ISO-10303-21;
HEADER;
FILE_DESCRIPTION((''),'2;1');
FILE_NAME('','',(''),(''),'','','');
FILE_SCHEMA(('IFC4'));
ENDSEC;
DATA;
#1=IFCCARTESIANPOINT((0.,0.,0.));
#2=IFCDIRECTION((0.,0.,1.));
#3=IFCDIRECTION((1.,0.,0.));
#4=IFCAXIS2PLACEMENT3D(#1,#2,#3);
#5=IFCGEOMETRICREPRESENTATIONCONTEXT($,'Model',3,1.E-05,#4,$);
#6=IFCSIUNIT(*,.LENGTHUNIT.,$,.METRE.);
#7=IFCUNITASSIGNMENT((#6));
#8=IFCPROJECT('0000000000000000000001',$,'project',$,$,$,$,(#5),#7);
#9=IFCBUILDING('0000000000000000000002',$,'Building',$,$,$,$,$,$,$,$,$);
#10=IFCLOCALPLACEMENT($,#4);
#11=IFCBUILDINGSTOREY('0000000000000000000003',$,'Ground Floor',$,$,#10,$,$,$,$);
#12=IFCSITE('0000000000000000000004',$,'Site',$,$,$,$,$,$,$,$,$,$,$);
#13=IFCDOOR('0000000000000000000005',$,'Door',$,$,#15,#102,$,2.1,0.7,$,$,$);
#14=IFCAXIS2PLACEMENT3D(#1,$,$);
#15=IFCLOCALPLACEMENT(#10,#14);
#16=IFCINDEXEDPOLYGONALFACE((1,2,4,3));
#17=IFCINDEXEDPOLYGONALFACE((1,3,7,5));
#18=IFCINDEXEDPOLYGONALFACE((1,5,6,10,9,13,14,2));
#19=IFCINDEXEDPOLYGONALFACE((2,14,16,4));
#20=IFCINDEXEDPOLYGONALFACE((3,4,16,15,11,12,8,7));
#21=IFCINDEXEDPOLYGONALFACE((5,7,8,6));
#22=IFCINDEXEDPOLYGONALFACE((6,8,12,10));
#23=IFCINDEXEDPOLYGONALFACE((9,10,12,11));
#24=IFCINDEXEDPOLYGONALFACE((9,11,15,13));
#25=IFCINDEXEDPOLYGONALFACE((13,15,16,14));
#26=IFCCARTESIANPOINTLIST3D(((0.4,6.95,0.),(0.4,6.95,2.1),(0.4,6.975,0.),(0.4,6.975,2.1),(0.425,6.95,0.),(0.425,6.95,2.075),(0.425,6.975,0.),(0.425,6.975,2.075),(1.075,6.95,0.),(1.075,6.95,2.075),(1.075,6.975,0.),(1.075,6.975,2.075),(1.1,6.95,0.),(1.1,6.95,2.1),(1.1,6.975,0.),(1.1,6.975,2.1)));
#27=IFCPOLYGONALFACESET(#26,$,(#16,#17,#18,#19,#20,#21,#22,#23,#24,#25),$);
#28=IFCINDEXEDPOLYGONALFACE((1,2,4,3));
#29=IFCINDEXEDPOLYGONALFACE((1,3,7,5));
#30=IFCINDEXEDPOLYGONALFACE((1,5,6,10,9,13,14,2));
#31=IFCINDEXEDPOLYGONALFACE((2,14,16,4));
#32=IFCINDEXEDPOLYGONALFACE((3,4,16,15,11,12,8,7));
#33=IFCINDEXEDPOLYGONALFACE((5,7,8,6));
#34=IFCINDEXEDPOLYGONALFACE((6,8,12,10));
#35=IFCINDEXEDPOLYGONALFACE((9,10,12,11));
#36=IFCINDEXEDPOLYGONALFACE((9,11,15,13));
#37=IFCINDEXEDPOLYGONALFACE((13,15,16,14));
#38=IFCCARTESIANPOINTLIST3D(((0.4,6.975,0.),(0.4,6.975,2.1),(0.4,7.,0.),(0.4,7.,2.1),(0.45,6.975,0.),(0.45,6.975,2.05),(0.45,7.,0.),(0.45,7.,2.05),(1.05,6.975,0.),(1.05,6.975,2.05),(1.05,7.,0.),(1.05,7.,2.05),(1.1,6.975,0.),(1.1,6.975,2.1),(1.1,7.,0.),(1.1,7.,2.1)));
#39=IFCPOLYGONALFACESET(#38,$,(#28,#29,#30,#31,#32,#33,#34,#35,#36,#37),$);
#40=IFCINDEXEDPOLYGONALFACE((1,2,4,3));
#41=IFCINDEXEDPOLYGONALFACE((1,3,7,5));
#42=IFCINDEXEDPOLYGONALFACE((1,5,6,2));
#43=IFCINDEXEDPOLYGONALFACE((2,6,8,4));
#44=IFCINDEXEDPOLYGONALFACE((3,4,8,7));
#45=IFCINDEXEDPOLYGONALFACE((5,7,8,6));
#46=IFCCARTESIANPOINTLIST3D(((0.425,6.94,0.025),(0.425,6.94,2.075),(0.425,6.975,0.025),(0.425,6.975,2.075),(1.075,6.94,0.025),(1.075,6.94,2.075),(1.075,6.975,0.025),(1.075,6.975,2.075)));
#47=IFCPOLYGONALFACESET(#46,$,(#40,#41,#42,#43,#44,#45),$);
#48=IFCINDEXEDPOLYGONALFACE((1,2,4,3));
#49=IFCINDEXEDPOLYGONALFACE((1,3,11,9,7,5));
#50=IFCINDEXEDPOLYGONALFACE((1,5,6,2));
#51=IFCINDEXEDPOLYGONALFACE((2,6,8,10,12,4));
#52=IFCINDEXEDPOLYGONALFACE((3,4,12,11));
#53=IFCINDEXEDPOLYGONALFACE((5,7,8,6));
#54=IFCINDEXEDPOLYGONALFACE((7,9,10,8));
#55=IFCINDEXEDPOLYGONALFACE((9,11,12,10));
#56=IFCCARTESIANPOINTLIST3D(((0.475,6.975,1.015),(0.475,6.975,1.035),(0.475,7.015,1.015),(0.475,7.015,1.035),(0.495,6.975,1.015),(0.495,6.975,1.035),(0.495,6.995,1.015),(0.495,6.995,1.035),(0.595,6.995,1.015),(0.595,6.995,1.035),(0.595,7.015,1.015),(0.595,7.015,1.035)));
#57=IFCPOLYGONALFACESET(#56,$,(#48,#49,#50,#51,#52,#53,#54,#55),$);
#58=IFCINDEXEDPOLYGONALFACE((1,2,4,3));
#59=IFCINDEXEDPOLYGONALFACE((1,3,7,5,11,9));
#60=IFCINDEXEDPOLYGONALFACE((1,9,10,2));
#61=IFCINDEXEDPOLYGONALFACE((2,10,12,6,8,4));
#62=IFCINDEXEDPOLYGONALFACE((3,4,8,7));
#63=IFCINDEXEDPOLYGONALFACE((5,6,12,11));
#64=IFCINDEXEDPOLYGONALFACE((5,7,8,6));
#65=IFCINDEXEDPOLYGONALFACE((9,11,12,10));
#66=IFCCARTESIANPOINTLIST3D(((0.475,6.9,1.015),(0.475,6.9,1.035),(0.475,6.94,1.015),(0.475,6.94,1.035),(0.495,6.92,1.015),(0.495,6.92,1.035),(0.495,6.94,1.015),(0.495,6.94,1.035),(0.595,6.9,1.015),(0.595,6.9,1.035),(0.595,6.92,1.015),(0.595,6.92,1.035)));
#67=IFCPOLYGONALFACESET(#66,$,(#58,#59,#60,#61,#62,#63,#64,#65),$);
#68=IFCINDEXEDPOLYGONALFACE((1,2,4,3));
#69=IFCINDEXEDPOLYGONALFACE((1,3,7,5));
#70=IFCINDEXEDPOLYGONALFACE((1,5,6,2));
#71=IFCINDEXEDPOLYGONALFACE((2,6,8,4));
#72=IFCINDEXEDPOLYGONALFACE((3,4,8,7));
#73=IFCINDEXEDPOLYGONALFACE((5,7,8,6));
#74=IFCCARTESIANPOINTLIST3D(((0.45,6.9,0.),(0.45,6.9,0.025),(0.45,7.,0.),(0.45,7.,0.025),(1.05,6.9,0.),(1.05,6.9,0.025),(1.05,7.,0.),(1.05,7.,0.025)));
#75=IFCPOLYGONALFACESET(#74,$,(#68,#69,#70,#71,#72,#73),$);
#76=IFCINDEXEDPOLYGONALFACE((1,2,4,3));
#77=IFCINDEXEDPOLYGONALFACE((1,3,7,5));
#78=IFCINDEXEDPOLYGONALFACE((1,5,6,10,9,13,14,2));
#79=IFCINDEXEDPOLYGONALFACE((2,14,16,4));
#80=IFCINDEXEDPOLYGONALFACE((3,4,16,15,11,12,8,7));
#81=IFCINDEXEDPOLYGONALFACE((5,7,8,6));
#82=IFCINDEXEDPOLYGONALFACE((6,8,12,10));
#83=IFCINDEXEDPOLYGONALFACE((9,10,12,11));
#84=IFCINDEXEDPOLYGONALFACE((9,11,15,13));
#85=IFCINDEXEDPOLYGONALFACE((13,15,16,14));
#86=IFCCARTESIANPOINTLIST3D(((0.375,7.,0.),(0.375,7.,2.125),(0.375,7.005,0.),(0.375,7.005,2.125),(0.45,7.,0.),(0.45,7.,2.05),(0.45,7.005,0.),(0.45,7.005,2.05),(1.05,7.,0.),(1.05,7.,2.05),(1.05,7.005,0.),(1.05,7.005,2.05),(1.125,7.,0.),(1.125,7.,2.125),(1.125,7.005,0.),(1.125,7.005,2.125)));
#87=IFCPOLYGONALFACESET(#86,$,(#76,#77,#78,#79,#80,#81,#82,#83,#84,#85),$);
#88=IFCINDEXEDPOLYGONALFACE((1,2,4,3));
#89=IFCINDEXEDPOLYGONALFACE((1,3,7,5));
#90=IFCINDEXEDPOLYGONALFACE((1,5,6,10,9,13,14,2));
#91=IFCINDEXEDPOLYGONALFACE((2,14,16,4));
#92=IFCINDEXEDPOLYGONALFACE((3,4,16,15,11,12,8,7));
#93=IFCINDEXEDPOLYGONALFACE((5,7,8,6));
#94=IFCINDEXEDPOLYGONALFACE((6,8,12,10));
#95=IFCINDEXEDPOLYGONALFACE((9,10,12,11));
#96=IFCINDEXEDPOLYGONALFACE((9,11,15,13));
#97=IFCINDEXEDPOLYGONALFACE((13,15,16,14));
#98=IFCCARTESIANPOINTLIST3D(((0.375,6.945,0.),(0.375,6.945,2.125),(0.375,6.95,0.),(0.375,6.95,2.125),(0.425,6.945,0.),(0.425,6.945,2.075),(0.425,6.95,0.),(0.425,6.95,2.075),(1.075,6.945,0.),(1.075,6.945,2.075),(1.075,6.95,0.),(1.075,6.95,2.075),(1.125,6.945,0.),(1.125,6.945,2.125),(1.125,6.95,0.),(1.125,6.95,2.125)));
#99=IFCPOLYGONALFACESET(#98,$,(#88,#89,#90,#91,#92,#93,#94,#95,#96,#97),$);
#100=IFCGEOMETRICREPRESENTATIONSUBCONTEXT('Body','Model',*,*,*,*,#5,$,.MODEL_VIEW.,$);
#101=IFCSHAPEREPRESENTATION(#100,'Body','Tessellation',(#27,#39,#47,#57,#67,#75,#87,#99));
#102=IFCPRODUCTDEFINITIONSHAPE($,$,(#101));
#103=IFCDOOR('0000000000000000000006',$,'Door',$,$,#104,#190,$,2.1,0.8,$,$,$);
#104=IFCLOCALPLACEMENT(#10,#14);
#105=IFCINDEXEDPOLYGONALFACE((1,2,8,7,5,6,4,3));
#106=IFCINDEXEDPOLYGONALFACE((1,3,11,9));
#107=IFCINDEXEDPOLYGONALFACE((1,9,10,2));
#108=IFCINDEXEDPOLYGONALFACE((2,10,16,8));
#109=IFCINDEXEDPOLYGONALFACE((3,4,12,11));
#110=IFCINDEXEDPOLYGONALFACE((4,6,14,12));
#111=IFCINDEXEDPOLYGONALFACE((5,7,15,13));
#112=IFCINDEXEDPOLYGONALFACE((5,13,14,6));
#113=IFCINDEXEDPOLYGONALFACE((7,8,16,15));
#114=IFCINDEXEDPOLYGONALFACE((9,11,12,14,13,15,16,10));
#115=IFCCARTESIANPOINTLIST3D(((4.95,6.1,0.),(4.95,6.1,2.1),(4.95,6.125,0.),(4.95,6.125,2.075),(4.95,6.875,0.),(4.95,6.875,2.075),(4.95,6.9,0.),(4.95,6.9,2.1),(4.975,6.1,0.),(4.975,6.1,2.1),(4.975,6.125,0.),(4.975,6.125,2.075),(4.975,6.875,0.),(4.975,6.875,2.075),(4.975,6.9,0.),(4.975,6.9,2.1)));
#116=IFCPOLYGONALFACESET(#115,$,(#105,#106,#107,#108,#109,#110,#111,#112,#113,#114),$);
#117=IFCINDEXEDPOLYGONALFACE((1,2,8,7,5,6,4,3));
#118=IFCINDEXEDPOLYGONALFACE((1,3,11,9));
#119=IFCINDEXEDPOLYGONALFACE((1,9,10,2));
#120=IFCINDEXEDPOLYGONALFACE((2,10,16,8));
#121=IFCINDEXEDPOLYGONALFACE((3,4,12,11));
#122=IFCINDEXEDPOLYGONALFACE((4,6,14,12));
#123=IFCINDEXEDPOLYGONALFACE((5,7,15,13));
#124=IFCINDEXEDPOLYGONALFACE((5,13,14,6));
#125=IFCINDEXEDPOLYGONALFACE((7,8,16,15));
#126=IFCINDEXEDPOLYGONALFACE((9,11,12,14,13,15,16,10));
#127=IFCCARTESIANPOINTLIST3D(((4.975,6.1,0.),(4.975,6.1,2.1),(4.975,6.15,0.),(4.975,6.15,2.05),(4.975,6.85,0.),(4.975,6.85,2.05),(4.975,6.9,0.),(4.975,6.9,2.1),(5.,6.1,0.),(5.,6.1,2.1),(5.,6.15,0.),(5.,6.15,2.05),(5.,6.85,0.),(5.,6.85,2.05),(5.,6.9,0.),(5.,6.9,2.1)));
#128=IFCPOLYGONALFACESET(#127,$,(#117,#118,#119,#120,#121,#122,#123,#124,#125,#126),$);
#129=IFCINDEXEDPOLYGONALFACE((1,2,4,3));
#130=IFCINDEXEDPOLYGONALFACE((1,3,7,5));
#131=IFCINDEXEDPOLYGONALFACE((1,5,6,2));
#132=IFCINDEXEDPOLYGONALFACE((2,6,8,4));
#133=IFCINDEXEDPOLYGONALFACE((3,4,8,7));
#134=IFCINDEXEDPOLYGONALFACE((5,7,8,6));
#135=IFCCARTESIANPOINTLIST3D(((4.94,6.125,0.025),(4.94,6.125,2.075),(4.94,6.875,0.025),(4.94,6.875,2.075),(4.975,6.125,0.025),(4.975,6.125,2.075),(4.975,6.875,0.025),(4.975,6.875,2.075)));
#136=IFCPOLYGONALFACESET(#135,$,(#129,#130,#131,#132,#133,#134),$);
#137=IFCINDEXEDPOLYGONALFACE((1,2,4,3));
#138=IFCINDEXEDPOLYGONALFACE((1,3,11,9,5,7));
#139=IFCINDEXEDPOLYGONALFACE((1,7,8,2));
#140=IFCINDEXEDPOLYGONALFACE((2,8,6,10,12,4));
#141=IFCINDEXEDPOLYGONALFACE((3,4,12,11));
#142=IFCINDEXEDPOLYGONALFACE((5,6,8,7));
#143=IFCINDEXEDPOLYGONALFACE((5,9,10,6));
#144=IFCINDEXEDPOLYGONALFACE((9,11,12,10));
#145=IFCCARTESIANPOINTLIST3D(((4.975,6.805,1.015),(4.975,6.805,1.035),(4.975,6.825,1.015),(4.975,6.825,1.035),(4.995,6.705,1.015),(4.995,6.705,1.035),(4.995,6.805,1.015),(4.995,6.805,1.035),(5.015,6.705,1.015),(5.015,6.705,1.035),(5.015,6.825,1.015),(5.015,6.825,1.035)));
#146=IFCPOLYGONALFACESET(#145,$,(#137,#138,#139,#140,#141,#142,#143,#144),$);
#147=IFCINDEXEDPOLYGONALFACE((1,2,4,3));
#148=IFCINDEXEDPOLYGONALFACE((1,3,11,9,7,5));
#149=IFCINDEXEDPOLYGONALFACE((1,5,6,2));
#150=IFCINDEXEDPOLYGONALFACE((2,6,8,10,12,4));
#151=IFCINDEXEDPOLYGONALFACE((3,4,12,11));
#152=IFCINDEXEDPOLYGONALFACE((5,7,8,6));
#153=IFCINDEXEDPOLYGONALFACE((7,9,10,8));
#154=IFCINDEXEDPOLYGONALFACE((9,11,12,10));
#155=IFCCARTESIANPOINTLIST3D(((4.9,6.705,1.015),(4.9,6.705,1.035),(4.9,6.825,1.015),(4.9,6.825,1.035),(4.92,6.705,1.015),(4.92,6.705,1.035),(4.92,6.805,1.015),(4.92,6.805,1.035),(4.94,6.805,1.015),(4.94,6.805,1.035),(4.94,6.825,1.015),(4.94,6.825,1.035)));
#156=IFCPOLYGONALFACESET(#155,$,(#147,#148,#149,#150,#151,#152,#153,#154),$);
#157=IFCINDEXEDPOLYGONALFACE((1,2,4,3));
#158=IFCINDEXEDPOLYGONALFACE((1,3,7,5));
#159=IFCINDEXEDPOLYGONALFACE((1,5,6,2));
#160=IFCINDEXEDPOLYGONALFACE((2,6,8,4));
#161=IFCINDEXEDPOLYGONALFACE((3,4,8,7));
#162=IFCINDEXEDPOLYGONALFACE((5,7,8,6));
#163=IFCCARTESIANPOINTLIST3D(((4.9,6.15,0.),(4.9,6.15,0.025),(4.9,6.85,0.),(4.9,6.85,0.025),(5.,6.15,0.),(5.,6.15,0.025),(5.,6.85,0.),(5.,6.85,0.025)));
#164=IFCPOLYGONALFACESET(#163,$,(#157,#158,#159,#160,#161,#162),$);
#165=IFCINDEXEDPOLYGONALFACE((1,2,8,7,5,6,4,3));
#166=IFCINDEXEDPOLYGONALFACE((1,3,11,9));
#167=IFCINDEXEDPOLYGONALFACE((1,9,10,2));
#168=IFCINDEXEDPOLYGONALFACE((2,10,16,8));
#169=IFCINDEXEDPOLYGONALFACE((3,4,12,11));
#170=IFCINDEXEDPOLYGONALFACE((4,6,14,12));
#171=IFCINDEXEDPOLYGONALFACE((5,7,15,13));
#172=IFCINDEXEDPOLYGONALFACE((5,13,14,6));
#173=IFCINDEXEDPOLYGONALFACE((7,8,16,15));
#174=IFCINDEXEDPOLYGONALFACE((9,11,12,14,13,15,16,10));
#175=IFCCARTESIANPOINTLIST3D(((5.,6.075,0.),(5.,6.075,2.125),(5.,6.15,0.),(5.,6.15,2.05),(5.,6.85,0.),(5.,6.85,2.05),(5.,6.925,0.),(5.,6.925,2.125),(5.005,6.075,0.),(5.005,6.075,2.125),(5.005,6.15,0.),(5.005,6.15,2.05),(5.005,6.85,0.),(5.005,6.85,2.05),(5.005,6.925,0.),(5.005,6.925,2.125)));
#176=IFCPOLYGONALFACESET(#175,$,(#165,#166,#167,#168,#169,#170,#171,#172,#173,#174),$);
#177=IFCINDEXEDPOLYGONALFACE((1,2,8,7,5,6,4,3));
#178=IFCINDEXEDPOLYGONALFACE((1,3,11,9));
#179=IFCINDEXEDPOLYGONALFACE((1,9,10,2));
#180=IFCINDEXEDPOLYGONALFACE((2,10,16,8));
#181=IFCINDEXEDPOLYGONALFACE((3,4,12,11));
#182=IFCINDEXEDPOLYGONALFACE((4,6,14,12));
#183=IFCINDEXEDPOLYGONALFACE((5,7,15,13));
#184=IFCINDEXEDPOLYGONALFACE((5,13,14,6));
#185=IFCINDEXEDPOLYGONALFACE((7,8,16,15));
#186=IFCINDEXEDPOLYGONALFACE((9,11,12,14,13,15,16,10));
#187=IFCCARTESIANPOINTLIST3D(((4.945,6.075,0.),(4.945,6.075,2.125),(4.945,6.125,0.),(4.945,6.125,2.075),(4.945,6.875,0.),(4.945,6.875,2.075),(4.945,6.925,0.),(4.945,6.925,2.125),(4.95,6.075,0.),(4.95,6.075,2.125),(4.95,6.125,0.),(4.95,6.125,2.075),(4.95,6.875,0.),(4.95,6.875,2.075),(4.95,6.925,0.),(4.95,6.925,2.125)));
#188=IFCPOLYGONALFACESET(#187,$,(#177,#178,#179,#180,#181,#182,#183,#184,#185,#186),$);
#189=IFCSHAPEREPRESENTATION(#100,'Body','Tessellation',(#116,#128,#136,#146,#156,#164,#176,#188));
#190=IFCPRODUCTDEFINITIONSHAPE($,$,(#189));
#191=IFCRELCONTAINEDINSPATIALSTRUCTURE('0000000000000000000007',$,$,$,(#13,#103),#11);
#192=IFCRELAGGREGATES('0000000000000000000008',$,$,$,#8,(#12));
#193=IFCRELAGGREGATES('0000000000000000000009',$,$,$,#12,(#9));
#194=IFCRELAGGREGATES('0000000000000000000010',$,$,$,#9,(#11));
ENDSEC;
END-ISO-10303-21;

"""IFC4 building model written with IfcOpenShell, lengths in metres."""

from ifc_helpers import new_model, si_unit, frame, origin_with_axes, place, context, subcontext, project, spatial, line, indexed_curve, outline, extrude, element, save


model = new_model("IFC4")

# Units and contexts
model_context = context("Model", 3, precision=1e-05, world=origin_with_axes())
body_context = subcontext(model_context, "Body", "Model", "MODEL_VIEW")
ifc_project = project(units=[si_unit("LENGTHUNIT", "METRE")], contexts=[model_context])

# Site, building, storey
site = spatial("IfcSite", under=ifc_project, Name="Site")
building = spatial("IfcBuilding", under=site, Name="Building")
storey_placement = place(None, origin_with_axes())
storey = spatial("IfcBuildingStorey", under=building, at=storey_placement, Name="Ground Floor")

# Doors
door_1_placement = place(storey_placement, frame((1.1, 7.0, 0.0), z_axis=(0.0, 0.0, 1.0), x_axis=(-1.0, 0.0, 0.0)))
element("IfcDoor", 1, at=door_1_placement, inside=storey, Name="Door", OverallHeight=2.1, OverallWidth=0.7, context=body_context, shape_type="SweptSolid", body=[
    extrude(outline(indexed_curve([(0.0, 0.0), (0.0, 2.1), (0.7, 2.1), (0.7, 0.0), (0.675, 0.0), (0.675, 2.075), (0.025, 2.075), (0.025, 0.0)], segments=[line(1, 2, 3, 4, 5, 6, 7, 8, 1)])), frame((0.0, 0.025, 0.0), z_axis=(0.0, -1.0, 0.0), x_axis=(1.0, 0.0, 0.0)), (0.0, 0.0, -1.0), 0.025),
    extrude(outline(indexed_curve([(0.0, 0.0), (0.0, 2.1), (0.7, 2.1), (0.7, 0.0), (0.65, 0.0), (0.65, 2.05), (0.05, 2.05), (0.05, 0.0)], segments=[line(1, 2, 3, 4, 5, 6, 7, 8, 1)])), frame((0.0, 0.0, 0.0), z_axis=(0.0, -1.0, 0.0), x_axis=(1.0, 0.0, 0.0)), (0.0, 0.0, -1.0), 0.025),
    extrude(outline(indexed_curve([(0.0, 0.0), (0.65, 0.0), (0.65, 0.035), (0.0, 0.035)], segments=[line(1, 2, 3, 4, 1)])), frame((0.025, 0.025, 0.025), z_axis=(0.0, 0.0, 1.0), x_axis=(1.0, 0.0, 0.0)), (0.0, 0.0, 1.0), 2.05),
    extrude(outline(indexed_curve([(0.0, 0.0), (0.0, -0.04), (-0.12, -0.04), (-0.12, -0.02), (-0.02, -0.02), (-0.02, 0.0)], segments=[line(1, 2, 3, 4, 5, 6, 1)])), frame((0.625, 0.025, 1.015), z_axis=(0.0, 0.0, 1.0), x_axis=(1.0, 0.0, 0.0)), (0.0, 0.0, 1.0), 0.02),
    extrude(outline(indexed_curve([(0.0, 0.0), (0.0, 0.04), (-0.12, 0.04), (-0.12, 0.02), (-0.02, 0.02), (-0.02, 0.0)], segments=[line(1, 2, 3, 4, 5, 6, 1)])), frame((0.625, 0.06, 1.015), z_axis=(0.0, 0.0, 1.0), x_axis=(1.0, 0.0, 0.0)), (0.0, 0.0, 1.0), 0.02),
    extrude(outline(indexed_curve([(0.0, 0.0), (0.6, 0.0), (0.6, 0.1), (0.0, 0.1)], segments=[line(1, 2, 3, 4, 1)])), frame((0.05, 0.0, 0.0), z_axis=(0.0, 0.0, 1.0), x_axis=(1.0, 0.0, 0.0)), (0.0, 0.0, 1.0), 0.025),
    extrude(outline(indexed_curve([(0.0, 0.0), (0.0, 2.125), (0.75, 2.125), (0.75, 0.0), (0.675, 0.0), (0.675, 2.05), (0.075, 2.05), (0.075, 0.0)], segments=[line(1, 2, 3, 4, 5, 6, 7, 8, 1)])), frame((-0.025, -0.005, 0.0), z_axis=(0.0, -1.0, 0.0), x_axis=(1.0, 0.0, 0.0)), (0.0, 0.0, -1.0), 0.005),
    extrude(outline(indexed_curve([(0.0, 0.0), (0.0, 2.125), (0.75, 2.125), (0.75, 0.0), (0.7, 0.0), (0.7, 2.075), (0.05, 2.075), (0.05, 0.0)], segments=[line(1, 2, 3, 4, 5, 6, 7, 8, 1)])), frame((-0.025, 0.05, 0.0), z_axis=(0.0, -1.0, 0.0), x_axis=(1.0, 0.0, 0.0)), (0.0, 0.0, -1.0), 0.005),
])
door_2_placement = place(storey_placement, frame((5.0, 6.1, 0.0), z_axis=(0.0, 0.0, 1.0), x_axis=(0.0, 1.0, 0.0)))
element("IfcDoor", 2, at=door_2_placement, inside=storey, Name="Door", OverallHeight=2.1, OverallWidth=0.8, context=body_context, shape_type="SweptSolid", body=[
    extrude(outline(indexed_curve([(0.0, 0.0), (0.0, 2.1), (0.8, 2.1), (0.8, 0.0), (0.775, 0.0), (0.775, 2.075), (0.025, 2.075), (0.025, 0.0)], segments=[line(1, 2, 3, 4, 5, 6, 7, 8, 1)])), frame((0.0, 0.025, 0.0), z_axis=(0.0, -1.0, 0.0), x_axis=(1.0, 0.0, 0.0)), (0.0, 0.0, -1.0), 0.025),
    extrude(outline(indexed_curve([(0.0, 0.0), (0.0, 2.1), (0.8, 2.1), (0.8, 0.0), (0.75, 0.0), (0.75, 2.05), (0.05, 2.05), (0.05, 0.0)], segments=[line(1, 2, 3, 4, 5, 6, 7, 8, 1)])), frame((0.0, 0.0, 0.0), z_axis=(0.0, -1.0, 0.0), x_axis=(1.0, 0.0, 0.0)), (0.0, 0.0, -1.0), 0.025),
    extrude(outline(indexed_curve([(0.0, 0.0), (0.75, 0.0), (0.75, 0.035), (0.0, 0.035)], segments=[line(1, 2, 3, 4, 1)])), frame((0.025, 0.025, 0.025), z_axis=(0.0, 0.0, 1.0), x_axis=(1.0, 0.0, 0.0)), (0.0, 0.0, 1.0), 2.05),
    extrude(outline(indexed_curve([(0.0, 0.0), (0.0, -0.04), (-0.12, -0.04), (-0.12, -0.02), (-0.02, -0.02), (-0.02, 0.0)], segments=[line(1, 2, 3, 4, 5, 6, 1)])), frame((0.725, 0.025, 1.015), z_axis=(0.0, 0.0, 1.0), x_axis=(1.0, 0.0, 0.0)), (0.0, 0.0, 1.0), 0.02),
    extrude(outline(indexed_curve([(0.0, 0.0), (0.0, 0.04), (-0.12, 0.04), (-0.12, 0.02), (-0.02, 0.02), (-0.02, 0.0)], segments=[line(1, 2, 3, 4, 5, 6, 1)])), frame((0.725, 0.06, 1.015), z_axis=(0.0, 0.0, 1.0), x_axis=(1.0, 0.0, 0.0)), (0.0, 0.0, 1.0), 0.02),
    extrude(outline(indexed_curve([(0.0, 0.0), (0.7, 0.0), (0.7, 0.1), (0.0, 0.1)], segments=[line(1, 2, 3, 4, 1)])), frame((0.05, 0.0, 0.0), z_axis=(0.0, 0.0, 1.0), x_axis=(1.0, 0.0, 0.0)), (0.0, 0.0, 1.0), 0.025),
    extrude(outline(indexed_curve([(0.0, 0.0), (0.0, 2.125), (0.85, 2.125), (0.85, 0.0), (0.775, 0.0), (0.775, 2.05), (0.075, 2.05), (0.075, 0.0)], segments=[line(1, 2, 3, 4, 5, 6, 7, 8, 1)])), frame((-0.025, -0.005, 0.0), z_axis=(0.0, -1.0, 0.0), x_axis=(1.0, 0.0, 0.0)), (0.0, 0.0, -1.0), 0.005),
    extrude(outline(indexed_curve([(0.0, 0.0), (0.0, 2.125), (0.85, 2.125), (0.85, 0.0), (0.8, 0.0), (0.8, 2.075), (0.05, 2.075), (0.05, 0.0)], segments=[line(1, 2, 3, 4, 5, 6, 7, 8, 1)])), frame((-0.025, 0.05, 0.0), z_axis=(0.0, -1.0, 0.0), x_axis=(1.0, 0.0, 0.0)), (0.0, 0.0, -1.0), 0.005),
])

save(model, "model.ifc")
